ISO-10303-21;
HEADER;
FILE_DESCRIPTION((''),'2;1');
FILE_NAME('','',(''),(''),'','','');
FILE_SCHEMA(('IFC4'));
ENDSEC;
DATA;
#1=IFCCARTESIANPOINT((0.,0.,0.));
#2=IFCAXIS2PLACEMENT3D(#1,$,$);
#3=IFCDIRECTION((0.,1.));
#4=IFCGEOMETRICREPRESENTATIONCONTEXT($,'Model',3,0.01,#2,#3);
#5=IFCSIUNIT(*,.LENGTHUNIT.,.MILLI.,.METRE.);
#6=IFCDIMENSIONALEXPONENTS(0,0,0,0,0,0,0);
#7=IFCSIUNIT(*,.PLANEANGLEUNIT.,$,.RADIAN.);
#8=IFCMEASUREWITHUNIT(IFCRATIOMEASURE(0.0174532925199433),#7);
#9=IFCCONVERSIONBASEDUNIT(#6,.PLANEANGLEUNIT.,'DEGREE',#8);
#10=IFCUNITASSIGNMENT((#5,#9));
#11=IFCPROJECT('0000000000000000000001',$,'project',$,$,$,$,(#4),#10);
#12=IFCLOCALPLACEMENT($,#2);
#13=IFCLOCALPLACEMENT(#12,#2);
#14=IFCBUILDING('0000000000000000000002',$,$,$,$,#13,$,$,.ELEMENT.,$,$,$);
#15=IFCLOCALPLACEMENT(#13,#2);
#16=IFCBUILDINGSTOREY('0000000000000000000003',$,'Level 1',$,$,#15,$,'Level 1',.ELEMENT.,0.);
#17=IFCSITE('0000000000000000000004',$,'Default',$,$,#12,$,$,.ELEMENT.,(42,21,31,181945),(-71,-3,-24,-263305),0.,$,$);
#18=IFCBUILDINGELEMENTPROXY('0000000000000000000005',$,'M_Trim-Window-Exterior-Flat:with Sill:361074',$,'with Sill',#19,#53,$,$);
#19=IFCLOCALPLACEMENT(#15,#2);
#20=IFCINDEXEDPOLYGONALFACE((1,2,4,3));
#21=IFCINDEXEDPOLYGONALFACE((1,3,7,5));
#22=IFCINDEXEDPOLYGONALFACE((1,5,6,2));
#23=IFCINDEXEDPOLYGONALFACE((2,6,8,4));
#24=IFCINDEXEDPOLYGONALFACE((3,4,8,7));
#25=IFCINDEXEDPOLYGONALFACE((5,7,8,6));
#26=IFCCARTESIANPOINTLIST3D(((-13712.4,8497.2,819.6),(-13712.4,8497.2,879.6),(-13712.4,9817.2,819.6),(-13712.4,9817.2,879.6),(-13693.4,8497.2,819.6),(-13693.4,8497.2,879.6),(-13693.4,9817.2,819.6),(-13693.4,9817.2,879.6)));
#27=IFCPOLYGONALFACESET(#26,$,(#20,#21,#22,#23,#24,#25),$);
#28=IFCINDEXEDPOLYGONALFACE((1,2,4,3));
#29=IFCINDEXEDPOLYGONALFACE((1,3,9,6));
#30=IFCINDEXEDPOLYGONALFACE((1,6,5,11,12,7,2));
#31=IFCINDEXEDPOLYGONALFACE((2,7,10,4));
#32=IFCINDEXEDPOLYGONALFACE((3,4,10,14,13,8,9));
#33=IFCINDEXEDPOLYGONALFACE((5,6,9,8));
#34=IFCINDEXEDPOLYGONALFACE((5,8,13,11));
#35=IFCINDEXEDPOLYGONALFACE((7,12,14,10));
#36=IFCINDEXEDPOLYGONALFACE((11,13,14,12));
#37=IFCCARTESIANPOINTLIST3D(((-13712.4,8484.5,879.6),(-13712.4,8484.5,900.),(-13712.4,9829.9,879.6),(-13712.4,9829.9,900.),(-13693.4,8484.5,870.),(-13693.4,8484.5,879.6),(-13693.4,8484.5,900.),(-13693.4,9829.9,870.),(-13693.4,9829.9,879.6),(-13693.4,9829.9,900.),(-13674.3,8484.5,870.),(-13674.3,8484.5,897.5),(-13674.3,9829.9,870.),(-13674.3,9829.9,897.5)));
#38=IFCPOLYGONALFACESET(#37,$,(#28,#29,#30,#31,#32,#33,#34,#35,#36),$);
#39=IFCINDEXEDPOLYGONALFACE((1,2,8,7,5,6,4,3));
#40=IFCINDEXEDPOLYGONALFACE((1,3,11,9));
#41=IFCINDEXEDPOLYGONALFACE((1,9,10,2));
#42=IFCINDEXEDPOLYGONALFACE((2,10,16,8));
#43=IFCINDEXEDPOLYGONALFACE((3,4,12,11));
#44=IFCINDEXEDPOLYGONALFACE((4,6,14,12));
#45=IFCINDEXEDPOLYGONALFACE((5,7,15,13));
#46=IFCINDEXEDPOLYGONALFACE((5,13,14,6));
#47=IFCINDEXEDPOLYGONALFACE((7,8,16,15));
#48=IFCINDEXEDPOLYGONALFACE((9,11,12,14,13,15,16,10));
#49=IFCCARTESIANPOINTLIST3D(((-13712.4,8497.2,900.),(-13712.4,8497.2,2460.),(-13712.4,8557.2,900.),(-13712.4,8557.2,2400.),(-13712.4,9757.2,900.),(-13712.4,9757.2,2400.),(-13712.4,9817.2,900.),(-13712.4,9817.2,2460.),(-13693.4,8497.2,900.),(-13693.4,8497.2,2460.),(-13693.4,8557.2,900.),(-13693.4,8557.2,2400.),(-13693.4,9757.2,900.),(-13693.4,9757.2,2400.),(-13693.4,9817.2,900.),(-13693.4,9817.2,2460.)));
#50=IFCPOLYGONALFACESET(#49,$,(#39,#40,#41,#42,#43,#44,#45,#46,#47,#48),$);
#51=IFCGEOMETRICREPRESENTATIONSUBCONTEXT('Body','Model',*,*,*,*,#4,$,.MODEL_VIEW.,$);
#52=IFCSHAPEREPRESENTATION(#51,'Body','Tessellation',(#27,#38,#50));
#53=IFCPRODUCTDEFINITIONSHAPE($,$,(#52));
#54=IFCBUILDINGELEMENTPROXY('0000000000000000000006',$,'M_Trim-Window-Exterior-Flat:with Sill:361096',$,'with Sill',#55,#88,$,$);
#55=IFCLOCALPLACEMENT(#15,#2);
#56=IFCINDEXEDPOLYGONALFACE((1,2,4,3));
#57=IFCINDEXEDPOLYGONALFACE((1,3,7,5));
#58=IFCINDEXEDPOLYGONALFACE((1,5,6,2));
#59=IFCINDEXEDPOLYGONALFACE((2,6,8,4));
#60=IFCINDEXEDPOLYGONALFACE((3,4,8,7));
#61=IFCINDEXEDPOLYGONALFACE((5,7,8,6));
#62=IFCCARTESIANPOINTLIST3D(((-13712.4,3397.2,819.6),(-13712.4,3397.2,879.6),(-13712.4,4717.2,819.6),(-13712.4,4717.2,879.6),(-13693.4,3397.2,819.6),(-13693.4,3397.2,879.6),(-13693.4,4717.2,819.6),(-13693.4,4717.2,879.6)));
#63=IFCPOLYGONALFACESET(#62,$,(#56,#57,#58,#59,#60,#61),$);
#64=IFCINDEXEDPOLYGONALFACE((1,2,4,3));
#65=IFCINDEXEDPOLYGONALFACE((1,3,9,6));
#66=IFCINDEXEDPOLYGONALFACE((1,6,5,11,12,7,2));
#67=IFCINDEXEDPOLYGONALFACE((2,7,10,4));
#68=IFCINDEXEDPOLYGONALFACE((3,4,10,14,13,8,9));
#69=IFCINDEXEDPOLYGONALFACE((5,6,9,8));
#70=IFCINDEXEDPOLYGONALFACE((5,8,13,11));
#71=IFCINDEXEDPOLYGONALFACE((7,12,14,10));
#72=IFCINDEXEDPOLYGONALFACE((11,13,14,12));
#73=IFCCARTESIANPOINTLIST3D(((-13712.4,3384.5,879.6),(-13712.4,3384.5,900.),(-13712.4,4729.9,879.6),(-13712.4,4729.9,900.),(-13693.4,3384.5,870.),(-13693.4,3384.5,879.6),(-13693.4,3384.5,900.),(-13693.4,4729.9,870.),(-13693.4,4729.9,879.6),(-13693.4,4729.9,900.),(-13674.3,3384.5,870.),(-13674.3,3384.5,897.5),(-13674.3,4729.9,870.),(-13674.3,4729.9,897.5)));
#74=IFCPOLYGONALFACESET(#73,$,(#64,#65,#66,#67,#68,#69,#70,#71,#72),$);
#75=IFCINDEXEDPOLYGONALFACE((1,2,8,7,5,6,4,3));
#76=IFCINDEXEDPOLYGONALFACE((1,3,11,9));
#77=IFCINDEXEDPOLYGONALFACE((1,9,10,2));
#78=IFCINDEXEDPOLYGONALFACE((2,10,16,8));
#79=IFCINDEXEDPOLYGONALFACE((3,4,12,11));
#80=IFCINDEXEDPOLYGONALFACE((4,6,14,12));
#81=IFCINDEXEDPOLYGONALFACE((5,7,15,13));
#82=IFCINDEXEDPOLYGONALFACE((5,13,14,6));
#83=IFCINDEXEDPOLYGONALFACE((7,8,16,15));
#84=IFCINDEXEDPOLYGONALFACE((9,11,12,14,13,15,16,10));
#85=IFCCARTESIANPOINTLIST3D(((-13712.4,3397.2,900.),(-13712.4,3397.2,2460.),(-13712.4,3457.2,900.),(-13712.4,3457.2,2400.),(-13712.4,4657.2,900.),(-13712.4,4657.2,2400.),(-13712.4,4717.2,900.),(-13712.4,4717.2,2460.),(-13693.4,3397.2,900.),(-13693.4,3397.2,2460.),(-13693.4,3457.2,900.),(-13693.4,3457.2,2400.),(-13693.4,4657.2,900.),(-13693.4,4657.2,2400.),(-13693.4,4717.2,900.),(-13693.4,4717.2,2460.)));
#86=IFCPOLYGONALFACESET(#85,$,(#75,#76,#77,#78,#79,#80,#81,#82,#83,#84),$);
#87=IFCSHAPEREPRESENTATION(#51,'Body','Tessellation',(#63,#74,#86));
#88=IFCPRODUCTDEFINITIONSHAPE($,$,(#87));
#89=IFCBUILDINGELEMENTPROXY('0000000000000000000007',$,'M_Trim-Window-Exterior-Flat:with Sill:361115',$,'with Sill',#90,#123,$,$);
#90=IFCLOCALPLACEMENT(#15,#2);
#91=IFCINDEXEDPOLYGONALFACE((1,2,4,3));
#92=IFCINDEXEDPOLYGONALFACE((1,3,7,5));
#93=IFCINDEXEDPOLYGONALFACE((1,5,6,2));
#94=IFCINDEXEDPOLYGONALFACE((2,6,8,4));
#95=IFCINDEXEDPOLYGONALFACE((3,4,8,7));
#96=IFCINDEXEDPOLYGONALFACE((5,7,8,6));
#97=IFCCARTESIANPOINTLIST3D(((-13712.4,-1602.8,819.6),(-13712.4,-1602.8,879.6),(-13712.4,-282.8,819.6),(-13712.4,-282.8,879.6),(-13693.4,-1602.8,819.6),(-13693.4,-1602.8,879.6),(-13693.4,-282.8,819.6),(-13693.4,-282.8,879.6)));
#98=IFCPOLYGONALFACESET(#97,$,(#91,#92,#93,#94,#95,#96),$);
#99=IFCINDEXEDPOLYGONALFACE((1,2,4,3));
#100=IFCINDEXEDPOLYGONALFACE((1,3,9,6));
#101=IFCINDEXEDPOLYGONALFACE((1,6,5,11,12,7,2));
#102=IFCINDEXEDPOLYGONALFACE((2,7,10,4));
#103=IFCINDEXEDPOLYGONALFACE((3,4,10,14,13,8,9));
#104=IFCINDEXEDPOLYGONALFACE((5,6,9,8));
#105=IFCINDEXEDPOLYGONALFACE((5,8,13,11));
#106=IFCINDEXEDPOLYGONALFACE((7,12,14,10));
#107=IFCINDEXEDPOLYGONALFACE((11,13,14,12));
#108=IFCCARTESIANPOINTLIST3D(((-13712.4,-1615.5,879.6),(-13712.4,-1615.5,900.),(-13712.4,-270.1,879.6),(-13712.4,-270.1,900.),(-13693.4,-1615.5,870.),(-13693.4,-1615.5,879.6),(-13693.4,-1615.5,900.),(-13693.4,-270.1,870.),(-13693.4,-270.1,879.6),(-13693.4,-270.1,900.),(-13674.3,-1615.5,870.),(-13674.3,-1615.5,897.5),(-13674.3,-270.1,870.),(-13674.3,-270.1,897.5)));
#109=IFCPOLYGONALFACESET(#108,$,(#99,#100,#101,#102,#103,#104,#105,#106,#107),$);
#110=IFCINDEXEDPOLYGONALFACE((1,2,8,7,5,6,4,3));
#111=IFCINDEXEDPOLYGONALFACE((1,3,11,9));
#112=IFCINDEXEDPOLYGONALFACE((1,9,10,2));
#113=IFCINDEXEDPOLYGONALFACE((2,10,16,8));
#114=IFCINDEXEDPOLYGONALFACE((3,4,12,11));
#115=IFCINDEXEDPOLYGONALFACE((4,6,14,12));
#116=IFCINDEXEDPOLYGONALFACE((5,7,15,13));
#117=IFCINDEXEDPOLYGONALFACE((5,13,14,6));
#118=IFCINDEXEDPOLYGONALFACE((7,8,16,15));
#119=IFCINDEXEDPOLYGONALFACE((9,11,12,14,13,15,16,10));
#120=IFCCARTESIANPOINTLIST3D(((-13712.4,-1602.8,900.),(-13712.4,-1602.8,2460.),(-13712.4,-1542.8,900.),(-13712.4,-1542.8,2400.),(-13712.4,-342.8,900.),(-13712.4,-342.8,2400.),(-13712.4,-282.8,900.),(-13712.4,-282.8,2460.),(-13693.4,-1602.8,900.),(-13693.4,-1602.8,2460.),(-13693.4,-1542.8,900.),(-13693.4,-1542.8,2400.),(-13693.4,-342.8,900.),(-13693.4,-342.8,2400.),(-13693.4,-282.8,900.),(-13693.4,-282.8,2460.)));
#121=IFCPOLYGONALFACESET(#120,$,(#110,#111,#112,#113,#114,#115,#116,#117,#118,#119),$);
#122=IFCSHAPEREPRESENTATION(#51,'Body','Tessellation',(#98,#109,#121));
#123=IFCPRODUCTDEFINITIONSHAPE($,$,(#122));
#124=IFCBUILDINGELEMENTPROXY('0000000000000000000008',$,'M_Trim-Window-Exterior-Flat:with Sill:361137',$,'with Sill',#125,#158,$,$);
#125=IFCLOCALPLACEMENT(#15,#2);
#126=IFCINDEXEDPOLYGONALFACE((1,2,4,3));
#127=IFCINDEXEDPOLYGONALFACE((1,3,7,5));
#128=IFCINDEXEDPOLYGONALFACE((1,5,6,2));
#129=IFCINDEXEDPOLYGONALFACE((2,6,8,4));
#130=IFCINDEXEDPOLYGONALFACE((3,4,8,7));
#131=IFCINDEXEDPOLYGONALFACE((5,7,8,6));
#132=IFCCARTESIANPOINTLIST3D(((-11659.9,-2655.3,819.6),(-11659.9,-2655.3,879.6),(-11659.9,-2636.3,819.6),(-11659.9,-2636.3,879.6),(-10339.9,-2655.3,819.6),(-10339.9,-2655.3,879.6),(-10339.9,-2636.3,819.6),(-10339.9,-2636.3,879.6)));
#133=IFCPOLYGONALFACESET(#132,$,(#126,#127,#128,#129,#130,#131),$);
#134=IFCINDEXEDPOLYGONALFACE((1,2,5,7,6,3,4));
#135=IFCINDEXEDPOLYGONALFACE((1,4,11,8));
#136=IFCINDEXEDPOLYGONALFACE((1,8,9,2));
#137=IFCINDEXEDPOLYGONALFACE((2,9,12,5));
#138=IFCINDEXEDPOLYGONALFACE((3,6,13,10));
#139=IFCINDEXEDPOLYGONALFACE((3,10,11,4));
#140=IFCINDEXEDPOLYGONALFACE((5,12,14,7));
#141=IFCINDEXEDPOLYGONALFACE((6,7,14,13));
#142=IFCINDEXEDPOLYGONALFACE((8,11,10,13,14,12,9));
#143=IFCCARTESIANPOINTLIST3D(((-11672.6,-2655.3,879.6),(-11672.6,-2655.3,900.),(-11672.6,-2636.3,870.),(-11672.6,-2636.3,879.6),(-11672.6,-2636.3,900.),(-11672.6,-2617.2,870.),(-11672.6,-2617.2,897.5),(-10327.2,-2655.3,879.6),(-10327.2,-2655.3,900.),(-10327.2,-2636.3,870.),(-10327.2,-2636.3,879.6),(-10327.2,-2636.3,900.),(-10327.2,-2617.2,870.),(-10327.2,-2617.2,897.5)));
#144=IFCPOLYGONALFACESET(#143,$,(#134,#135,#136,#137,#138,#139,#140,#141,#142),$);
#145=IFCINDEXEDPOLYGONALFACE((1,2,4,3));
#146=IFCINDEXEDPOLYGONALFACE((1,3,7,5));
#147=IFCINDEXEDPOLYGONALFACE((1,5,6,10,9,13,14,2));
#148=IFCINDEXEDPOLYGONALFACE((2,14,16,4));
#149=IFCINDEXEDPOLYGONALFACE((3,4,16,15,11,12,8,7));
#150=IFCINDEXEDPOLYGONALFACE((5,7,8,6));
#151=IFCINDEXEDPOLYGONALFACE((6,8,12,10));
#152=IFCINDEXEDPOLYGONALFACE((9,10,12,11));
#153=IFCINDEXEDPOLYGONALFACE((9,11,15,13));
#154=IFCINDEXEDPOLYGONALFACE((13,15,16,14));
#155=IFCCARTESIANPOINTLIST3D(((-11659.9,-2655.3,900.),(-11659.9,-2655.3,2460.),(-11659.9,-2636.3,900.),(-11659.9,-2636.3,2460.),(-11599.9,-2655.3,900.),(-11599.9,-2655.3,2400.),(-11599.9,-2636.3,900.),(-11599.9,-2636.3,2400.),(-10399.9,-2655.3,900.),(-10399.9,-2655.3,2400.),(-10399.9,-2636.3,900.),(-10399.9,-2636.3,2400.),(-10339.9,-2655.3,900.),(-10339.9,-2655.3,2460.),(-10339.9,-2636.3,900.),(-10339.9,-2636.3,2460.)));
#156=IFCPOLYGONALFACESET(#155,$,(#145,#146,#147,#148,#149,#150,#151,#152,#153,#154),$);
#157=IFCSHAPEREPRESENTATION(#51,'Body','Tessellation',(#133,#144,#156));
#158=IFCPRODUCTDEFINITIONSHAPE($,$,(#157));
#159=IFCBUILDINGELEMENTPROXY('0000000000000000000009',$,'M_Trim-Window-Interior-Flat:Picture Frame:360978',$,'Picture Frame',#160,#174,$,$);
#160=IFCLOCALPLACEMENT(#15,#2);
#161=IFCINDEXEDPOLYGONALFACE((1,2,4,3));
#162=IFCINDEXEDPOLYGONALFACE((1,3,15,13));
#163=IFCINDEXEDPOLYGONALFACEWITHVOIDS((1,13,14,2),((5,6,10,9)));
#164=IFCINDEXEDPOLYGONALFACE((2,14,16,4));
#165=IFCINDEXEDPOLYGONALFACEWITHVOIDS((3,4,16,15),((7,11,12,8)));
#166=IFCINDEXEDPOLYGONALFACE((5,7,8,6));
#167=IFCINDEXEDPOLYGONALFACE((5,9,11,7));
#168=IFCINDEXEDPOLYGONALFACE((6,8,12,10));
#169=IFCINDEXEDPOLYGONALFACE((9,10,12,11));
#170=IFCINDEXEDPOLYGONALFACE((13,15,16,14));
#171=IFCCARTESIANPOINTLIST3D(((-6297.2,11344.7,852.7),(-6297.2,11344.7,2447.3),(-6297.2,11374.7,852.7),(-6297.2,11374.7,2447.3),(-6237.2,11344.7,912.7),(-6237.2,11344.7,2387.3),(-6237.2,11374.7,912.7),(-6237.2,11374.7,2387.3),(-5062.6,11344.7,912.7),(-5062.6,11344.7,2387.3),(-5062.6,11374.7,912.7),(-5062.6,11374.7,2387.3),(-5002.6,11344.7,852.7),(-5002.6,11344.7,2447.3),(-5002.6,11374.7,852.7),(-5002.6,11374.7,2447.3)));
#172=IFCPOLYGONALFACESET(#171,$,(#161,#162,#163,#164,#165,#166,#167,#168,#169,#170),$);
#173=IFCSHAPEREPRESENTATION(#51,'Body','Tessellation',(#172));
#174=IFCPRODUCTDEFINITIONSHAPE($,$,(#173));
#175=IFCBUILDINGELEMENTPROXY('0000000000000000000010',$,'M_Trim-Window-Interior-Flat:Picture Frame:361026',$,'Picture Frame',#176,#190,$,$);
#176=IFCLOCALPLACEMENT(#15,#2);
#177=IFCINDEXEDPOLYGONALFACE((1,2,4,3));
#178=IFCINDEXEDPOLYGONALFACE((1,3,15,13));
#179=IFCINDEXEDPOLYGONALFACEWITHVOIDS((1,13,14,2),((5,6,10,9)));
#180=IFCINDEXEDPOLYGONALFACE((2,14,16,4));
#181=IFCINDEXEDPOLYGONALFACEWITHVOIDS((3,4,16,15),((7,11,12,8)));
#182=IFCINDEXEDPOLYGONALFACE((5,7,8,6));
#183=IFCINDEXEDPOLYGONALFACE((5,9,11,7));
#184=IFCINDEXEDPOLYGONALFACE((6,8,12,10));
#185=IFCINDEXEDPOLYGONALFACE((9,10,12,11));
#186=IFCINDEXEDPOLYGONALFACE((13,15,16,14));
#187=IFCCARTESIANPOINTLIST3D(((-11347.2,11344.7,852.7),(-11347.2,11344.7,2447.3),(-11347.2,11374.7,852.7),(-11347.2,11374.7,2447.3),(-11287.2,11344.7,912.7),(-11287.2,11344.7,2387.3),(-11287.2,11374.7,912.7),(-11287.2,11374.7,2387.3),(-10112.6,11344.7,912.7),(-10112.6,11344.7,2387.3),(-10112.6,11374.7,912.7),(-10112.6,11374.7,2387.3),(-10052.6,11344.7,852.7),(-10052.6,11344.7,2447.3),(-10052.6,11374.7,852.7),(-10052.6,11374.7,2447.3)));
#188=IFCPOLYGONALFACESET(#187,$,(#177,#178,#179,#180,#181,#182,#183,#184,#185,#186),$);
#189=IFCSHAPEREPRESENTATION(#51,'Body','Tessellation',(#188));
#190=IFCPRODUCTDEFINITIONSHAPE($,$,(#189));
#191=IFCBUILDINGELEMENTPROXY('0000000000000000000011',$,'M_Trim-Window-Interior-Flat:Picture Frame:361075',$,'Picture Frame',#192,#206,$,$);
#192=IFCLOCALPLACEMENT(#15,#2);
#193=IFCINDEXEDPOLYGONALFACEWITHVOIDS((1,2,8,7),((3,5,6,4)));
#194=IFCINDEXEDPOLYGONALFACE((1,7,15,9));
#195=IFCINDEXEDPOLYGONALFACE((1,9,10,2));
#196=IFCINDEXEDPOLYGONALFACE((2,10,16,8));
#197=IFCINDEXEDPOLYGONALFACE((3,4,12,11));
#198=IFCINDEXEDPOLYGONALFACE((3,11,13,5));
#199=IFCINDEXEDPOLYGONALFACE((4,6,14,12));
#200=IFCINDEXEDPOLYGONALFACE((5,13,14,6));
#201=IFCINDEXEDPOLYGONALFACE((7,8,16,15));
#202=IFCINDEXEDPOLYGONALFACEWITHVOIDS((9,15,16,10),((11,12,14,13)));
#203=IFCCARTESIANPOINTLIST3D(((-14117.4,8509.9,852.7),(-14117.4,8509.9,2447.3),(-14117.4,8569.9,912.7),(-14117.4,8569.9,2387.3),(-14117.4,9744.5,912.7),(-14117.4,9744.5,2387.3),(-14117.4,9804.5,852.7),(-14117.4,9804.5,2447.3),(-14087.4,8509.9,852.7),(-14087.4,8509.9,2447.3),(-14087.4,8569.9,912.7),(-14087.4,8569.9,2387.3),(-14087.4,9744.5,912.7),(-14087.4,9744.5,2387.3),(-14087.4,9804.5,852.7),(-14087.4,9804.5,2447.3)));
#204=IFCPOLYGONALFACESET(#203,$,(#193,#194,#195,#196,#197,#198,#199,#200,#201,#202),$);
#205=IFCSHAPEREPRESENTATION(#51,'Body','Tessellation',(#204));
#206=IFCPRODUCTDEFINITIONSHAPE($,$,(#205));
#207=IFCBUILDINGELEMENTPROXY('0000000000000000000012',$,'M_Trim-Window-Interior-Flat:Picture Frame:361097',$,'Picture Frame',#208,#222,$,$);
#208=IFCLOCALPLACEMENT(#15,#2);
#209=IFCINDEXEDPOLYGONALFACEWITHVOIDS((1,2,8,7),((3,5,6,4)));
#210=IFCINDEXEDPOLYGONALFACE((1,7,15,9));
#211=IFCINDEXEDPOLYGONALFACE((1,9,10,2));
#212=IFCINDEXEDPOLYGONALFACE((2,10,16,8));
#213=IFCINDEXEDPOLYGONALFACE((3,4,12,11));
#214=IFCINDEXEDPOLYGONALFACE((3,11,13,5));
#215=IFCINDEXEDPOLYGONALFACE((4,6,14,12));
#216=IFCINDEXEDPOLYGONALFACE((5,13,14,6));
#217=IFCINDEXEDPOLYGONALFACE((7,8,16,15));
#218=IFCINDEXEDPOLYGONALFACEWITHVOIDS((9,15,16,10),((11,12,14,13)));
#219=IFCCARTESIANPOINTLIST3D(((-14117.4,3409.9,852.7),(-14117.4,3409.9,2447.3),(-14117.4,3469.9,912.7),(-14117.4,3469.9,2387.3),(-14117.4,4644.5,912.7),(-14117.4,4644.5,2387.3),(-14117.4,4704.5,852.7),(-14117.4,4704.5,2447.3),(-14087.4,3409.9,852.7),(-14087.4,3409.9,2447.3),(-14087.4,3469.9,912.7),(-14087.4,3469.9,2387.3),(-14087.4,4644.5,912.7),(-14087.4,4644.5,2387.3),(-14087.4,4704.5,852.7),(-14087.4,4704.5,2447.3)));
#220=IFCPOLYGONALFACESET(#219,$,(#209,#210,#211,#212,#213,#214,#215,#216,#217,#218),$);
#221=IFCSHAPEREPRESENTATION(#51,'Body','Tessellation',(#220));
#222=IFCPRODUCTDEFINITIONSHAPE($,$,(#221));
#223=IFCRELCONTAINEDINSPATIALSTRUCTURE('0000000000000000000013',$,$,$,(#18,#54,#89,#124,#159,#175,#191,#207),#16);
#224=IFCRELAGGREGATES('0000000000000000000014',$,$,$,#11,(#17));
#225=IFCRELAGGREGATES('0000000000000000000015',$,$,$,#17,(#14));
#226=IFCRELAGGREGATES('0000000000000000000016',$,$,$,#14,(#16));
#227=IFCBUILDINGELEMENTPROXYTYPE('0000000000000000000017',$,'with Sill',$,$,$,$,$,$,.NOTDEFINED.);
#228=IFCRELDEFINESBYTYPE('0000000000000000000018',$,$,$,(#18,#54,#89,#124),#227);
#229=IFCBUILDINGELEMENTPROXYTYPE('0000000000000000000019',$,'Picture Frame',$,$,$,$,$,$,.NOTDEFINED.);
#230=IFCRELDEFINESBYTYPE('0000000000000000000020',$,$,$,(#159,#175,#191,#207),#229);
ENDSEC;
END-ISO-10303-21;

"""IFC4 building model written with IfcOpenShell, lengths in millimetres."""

from ifc_helpers import new_model, entity, si_unit, converted_unit, direction, frame, frame_2d, origin, place, context, subcontext, project, spatial, polyline, rectangle, outline, extrude, source, transform, mapped, type_object, type_shapes, element, save


model = new_model("IFC4")

# Units and contexts
model_context = context("Model", 3, precision=0.01, world=origin(), true_north=direction((0.0, 1.0)))
body_context = subcontext(model_context, "Body", "Model", "MODEL_VIEW")
ifc_project = project(units=[si_unit("LENGTHUNIT", "METRE", prefix="MILLI"), converted_unit("PLANEANGLEUNIT", "DEGREE", entity("IfcRatioMeasure", 0.0174532925199433), si_unit("PLANEANGLEUNIT", "RADIAN"), dimensions=[0, 0, 0, 0, 0, 0, 0])], contexts=[model_context])

# Site, building, storey
site_placement = place(None, origin())
site = spatial("IfcSite", under=ifc_project, at=site_placement, Name="Default", CompositionType="ELEMENT", RefLatitude=(42, 21, 31, 181945), RefLongitude=(-71, -3, -24, -263305), RefElevation=0.0)
building_placement = place(site_placement, origin())
building = spatial("IfcBuilding", under=site, at=building_placement, CompositionType="ELEMENT")
storey_placement = place(building_placement, origin())
storey = spatial("IfcBuildingStorey", under=building, at=storey_placement, Name="Level 1", LongName="Level 1", CompositionType="ELEMENT", Elevation=0.0)

# Building element proxies
building_element_proxy_type_1 = type_object("IfcBuildingElementProxyType", Name="with Sill", PredefinedType="NOTDEFINED")
shared_shape_1 = source(origin(), body_context, "Body", "SweptSolid", [
    extrude(rectangle(XDim=1320.0, YDim=60.0, at=frame_2d((0.0, 0.0), x_axis=(1.0, 0.0))), frame((0.0, -1550.4, 0.0), z_axis=(0.0, 0.0, 1.0), x_axis=(-1.0, 0.0, 0.0)), (0.0, 0.0, 1.0), 19.1),
    extrude(outline(polyline([(-19.0, -15.2), (0.0, -15.2), (0.0, -5.7), (19.0, -5.7), (19.0, 14.8), (0.0, 14.8), (-19.0, 12.3), (-19.0, -15.2)])), frame((-672.7, -1514.8, 19.0), z_axis=(1.0, 0.0, 0.0), x_axis=(0.0, 0.0, -1.0)), (0.0, 0.0, 1.0), 1345.4),
    extrude(outline(polyline([(-795.0, -660.0), (765.0, -660.0), (765.0, -600.0), (-735.0, -600.0), (-735.0, 600.0), (765.0, 600.0), (765.0, 660.0), (-795.0, 660.0), (-795.0, -660.0)])), frame((0.0, -735.0, 0.0), z_axis=(0.0, 0.0, 1.0), x_axis=(0.0, -1.0, 0.0)), (0.0, 0.0, 1.0), 19.1),
])
type_shapes(building_element_proxy_type_1, [shared_shape_1])
for number, where, z_axis, x_axis, name in (
    (1, (-13712.4, 9157.2, 2400.0), (1.0, 0.0, 0.0), (0.0, 1.0, 0.0), "M_Trim-Window-Exterior-Flat:with Sill:361074"),
    (2, (-13712.4, 4057.2, 2400.0), (1.0, 0.0, 0.0), (0.0, 1.0, 0.0), "M_Trim-Window-Exterior-Flat:with Sill:361096"),
    (3, (-13712.4, -942.8, 2400.0), (1.0, 0.0, 0.0), (0.0, 1.0, 0.0), "M_Trim-Window-Exterior-Flat:with Sill:361115"),
    (4, (-10999.9, -2655.3, 2400.0), (0.0, 1.0, 0.0), (-1.0, 0.0, 0.0), "M_Trim-Window-Exterior-Flat:with Sill:361137"),
):
    element("IfcBuildingElementProxy", number, at=place(storey_placement, frame(where, z_axis=z_axis, x_axis=x_axis)), inside=storey, type_object=building_element_proxy_type_1, Name=name, ObjectType="with Sill", context=body_context, shape_type="MappedRepresentation", body=[
        mapped(shared_shape_1, transform((0.0, 0.0, 0.0), scale=1.0)),
    ])
building_element_proxy_type_2 = type_object("IfcBuildingElementProxyType", Name="Picture Frame", PredefinedType="NOTDEFINED")
shared_shape_2 = source(origin(), body_context, "Body", "SweptSolid", [
    extrude(outline(polyline([(-647.3, -797.3), (647.3, -797.3), (647.3, 797.3), (-647.3, 797.3), (-647.3, -797.3)]), holes=[polyline([(-587.3, -737.3), (-587.3, 737.3), (587.3, 737.3), (587.3, -737.3), (-587.3, -737.3)])]), frame((0.0, -750.0, 0.0), z_axis=(0.0, 0.0, 1.0), x_axis=(-1.0, 0.0, 0.0)), (0.0, 0.0, 1.0), 30.0),
])
type_shapes(building_element_proxy_type_2, [shared_shape_2])
for number, where, z_axis, x_axis, name in (
    (5, (-5649.9, 11344.7, 2400.0), (0.0, 1.0, 0.0), (-1.0, 0.0, 0.0), "M_Trim-Window-Interior-Flat:Picture Frame:360978"),
    (6, (-10699.9, 11344.7, 2400.0), (0.0, 1.0, 0.0), (-1.0, 0.0, 0.0), "M_Trim-Window-Interior-Flat:Picture Frame:361026"),
    (7, (-14087.4, 9157.2, 2400.0), (-1.0, 0.0, 0.0), (0.0, -1.0, 0.0), "M_Trim-Window-Interior-Flat:Picture Frame:361075"),
    (8, (-14087.4, 4057.2, 2400.0), (-1.0, 0.0, 0.0), (0.0, -1.0, 0.0), "M_Trim-Window-Interior-Flat:Picture Frame:361097"),
):
    element("IfcBuildingElementProxy", number, at=place(storey_placement, frame(where, z_axis=z_axis, x_axis=x_axis)), inside=storey, type_object=building_element_proxy_type_2, Name=name, ObjectType="Picture Frame", context=body_context, shape_type="MappedRepresentation", body=[
        mapped(shared_shape_2, transform((0.0, 0.0, 0.0), scale=1.0)),
    ])

save(model, "model.ifc")
